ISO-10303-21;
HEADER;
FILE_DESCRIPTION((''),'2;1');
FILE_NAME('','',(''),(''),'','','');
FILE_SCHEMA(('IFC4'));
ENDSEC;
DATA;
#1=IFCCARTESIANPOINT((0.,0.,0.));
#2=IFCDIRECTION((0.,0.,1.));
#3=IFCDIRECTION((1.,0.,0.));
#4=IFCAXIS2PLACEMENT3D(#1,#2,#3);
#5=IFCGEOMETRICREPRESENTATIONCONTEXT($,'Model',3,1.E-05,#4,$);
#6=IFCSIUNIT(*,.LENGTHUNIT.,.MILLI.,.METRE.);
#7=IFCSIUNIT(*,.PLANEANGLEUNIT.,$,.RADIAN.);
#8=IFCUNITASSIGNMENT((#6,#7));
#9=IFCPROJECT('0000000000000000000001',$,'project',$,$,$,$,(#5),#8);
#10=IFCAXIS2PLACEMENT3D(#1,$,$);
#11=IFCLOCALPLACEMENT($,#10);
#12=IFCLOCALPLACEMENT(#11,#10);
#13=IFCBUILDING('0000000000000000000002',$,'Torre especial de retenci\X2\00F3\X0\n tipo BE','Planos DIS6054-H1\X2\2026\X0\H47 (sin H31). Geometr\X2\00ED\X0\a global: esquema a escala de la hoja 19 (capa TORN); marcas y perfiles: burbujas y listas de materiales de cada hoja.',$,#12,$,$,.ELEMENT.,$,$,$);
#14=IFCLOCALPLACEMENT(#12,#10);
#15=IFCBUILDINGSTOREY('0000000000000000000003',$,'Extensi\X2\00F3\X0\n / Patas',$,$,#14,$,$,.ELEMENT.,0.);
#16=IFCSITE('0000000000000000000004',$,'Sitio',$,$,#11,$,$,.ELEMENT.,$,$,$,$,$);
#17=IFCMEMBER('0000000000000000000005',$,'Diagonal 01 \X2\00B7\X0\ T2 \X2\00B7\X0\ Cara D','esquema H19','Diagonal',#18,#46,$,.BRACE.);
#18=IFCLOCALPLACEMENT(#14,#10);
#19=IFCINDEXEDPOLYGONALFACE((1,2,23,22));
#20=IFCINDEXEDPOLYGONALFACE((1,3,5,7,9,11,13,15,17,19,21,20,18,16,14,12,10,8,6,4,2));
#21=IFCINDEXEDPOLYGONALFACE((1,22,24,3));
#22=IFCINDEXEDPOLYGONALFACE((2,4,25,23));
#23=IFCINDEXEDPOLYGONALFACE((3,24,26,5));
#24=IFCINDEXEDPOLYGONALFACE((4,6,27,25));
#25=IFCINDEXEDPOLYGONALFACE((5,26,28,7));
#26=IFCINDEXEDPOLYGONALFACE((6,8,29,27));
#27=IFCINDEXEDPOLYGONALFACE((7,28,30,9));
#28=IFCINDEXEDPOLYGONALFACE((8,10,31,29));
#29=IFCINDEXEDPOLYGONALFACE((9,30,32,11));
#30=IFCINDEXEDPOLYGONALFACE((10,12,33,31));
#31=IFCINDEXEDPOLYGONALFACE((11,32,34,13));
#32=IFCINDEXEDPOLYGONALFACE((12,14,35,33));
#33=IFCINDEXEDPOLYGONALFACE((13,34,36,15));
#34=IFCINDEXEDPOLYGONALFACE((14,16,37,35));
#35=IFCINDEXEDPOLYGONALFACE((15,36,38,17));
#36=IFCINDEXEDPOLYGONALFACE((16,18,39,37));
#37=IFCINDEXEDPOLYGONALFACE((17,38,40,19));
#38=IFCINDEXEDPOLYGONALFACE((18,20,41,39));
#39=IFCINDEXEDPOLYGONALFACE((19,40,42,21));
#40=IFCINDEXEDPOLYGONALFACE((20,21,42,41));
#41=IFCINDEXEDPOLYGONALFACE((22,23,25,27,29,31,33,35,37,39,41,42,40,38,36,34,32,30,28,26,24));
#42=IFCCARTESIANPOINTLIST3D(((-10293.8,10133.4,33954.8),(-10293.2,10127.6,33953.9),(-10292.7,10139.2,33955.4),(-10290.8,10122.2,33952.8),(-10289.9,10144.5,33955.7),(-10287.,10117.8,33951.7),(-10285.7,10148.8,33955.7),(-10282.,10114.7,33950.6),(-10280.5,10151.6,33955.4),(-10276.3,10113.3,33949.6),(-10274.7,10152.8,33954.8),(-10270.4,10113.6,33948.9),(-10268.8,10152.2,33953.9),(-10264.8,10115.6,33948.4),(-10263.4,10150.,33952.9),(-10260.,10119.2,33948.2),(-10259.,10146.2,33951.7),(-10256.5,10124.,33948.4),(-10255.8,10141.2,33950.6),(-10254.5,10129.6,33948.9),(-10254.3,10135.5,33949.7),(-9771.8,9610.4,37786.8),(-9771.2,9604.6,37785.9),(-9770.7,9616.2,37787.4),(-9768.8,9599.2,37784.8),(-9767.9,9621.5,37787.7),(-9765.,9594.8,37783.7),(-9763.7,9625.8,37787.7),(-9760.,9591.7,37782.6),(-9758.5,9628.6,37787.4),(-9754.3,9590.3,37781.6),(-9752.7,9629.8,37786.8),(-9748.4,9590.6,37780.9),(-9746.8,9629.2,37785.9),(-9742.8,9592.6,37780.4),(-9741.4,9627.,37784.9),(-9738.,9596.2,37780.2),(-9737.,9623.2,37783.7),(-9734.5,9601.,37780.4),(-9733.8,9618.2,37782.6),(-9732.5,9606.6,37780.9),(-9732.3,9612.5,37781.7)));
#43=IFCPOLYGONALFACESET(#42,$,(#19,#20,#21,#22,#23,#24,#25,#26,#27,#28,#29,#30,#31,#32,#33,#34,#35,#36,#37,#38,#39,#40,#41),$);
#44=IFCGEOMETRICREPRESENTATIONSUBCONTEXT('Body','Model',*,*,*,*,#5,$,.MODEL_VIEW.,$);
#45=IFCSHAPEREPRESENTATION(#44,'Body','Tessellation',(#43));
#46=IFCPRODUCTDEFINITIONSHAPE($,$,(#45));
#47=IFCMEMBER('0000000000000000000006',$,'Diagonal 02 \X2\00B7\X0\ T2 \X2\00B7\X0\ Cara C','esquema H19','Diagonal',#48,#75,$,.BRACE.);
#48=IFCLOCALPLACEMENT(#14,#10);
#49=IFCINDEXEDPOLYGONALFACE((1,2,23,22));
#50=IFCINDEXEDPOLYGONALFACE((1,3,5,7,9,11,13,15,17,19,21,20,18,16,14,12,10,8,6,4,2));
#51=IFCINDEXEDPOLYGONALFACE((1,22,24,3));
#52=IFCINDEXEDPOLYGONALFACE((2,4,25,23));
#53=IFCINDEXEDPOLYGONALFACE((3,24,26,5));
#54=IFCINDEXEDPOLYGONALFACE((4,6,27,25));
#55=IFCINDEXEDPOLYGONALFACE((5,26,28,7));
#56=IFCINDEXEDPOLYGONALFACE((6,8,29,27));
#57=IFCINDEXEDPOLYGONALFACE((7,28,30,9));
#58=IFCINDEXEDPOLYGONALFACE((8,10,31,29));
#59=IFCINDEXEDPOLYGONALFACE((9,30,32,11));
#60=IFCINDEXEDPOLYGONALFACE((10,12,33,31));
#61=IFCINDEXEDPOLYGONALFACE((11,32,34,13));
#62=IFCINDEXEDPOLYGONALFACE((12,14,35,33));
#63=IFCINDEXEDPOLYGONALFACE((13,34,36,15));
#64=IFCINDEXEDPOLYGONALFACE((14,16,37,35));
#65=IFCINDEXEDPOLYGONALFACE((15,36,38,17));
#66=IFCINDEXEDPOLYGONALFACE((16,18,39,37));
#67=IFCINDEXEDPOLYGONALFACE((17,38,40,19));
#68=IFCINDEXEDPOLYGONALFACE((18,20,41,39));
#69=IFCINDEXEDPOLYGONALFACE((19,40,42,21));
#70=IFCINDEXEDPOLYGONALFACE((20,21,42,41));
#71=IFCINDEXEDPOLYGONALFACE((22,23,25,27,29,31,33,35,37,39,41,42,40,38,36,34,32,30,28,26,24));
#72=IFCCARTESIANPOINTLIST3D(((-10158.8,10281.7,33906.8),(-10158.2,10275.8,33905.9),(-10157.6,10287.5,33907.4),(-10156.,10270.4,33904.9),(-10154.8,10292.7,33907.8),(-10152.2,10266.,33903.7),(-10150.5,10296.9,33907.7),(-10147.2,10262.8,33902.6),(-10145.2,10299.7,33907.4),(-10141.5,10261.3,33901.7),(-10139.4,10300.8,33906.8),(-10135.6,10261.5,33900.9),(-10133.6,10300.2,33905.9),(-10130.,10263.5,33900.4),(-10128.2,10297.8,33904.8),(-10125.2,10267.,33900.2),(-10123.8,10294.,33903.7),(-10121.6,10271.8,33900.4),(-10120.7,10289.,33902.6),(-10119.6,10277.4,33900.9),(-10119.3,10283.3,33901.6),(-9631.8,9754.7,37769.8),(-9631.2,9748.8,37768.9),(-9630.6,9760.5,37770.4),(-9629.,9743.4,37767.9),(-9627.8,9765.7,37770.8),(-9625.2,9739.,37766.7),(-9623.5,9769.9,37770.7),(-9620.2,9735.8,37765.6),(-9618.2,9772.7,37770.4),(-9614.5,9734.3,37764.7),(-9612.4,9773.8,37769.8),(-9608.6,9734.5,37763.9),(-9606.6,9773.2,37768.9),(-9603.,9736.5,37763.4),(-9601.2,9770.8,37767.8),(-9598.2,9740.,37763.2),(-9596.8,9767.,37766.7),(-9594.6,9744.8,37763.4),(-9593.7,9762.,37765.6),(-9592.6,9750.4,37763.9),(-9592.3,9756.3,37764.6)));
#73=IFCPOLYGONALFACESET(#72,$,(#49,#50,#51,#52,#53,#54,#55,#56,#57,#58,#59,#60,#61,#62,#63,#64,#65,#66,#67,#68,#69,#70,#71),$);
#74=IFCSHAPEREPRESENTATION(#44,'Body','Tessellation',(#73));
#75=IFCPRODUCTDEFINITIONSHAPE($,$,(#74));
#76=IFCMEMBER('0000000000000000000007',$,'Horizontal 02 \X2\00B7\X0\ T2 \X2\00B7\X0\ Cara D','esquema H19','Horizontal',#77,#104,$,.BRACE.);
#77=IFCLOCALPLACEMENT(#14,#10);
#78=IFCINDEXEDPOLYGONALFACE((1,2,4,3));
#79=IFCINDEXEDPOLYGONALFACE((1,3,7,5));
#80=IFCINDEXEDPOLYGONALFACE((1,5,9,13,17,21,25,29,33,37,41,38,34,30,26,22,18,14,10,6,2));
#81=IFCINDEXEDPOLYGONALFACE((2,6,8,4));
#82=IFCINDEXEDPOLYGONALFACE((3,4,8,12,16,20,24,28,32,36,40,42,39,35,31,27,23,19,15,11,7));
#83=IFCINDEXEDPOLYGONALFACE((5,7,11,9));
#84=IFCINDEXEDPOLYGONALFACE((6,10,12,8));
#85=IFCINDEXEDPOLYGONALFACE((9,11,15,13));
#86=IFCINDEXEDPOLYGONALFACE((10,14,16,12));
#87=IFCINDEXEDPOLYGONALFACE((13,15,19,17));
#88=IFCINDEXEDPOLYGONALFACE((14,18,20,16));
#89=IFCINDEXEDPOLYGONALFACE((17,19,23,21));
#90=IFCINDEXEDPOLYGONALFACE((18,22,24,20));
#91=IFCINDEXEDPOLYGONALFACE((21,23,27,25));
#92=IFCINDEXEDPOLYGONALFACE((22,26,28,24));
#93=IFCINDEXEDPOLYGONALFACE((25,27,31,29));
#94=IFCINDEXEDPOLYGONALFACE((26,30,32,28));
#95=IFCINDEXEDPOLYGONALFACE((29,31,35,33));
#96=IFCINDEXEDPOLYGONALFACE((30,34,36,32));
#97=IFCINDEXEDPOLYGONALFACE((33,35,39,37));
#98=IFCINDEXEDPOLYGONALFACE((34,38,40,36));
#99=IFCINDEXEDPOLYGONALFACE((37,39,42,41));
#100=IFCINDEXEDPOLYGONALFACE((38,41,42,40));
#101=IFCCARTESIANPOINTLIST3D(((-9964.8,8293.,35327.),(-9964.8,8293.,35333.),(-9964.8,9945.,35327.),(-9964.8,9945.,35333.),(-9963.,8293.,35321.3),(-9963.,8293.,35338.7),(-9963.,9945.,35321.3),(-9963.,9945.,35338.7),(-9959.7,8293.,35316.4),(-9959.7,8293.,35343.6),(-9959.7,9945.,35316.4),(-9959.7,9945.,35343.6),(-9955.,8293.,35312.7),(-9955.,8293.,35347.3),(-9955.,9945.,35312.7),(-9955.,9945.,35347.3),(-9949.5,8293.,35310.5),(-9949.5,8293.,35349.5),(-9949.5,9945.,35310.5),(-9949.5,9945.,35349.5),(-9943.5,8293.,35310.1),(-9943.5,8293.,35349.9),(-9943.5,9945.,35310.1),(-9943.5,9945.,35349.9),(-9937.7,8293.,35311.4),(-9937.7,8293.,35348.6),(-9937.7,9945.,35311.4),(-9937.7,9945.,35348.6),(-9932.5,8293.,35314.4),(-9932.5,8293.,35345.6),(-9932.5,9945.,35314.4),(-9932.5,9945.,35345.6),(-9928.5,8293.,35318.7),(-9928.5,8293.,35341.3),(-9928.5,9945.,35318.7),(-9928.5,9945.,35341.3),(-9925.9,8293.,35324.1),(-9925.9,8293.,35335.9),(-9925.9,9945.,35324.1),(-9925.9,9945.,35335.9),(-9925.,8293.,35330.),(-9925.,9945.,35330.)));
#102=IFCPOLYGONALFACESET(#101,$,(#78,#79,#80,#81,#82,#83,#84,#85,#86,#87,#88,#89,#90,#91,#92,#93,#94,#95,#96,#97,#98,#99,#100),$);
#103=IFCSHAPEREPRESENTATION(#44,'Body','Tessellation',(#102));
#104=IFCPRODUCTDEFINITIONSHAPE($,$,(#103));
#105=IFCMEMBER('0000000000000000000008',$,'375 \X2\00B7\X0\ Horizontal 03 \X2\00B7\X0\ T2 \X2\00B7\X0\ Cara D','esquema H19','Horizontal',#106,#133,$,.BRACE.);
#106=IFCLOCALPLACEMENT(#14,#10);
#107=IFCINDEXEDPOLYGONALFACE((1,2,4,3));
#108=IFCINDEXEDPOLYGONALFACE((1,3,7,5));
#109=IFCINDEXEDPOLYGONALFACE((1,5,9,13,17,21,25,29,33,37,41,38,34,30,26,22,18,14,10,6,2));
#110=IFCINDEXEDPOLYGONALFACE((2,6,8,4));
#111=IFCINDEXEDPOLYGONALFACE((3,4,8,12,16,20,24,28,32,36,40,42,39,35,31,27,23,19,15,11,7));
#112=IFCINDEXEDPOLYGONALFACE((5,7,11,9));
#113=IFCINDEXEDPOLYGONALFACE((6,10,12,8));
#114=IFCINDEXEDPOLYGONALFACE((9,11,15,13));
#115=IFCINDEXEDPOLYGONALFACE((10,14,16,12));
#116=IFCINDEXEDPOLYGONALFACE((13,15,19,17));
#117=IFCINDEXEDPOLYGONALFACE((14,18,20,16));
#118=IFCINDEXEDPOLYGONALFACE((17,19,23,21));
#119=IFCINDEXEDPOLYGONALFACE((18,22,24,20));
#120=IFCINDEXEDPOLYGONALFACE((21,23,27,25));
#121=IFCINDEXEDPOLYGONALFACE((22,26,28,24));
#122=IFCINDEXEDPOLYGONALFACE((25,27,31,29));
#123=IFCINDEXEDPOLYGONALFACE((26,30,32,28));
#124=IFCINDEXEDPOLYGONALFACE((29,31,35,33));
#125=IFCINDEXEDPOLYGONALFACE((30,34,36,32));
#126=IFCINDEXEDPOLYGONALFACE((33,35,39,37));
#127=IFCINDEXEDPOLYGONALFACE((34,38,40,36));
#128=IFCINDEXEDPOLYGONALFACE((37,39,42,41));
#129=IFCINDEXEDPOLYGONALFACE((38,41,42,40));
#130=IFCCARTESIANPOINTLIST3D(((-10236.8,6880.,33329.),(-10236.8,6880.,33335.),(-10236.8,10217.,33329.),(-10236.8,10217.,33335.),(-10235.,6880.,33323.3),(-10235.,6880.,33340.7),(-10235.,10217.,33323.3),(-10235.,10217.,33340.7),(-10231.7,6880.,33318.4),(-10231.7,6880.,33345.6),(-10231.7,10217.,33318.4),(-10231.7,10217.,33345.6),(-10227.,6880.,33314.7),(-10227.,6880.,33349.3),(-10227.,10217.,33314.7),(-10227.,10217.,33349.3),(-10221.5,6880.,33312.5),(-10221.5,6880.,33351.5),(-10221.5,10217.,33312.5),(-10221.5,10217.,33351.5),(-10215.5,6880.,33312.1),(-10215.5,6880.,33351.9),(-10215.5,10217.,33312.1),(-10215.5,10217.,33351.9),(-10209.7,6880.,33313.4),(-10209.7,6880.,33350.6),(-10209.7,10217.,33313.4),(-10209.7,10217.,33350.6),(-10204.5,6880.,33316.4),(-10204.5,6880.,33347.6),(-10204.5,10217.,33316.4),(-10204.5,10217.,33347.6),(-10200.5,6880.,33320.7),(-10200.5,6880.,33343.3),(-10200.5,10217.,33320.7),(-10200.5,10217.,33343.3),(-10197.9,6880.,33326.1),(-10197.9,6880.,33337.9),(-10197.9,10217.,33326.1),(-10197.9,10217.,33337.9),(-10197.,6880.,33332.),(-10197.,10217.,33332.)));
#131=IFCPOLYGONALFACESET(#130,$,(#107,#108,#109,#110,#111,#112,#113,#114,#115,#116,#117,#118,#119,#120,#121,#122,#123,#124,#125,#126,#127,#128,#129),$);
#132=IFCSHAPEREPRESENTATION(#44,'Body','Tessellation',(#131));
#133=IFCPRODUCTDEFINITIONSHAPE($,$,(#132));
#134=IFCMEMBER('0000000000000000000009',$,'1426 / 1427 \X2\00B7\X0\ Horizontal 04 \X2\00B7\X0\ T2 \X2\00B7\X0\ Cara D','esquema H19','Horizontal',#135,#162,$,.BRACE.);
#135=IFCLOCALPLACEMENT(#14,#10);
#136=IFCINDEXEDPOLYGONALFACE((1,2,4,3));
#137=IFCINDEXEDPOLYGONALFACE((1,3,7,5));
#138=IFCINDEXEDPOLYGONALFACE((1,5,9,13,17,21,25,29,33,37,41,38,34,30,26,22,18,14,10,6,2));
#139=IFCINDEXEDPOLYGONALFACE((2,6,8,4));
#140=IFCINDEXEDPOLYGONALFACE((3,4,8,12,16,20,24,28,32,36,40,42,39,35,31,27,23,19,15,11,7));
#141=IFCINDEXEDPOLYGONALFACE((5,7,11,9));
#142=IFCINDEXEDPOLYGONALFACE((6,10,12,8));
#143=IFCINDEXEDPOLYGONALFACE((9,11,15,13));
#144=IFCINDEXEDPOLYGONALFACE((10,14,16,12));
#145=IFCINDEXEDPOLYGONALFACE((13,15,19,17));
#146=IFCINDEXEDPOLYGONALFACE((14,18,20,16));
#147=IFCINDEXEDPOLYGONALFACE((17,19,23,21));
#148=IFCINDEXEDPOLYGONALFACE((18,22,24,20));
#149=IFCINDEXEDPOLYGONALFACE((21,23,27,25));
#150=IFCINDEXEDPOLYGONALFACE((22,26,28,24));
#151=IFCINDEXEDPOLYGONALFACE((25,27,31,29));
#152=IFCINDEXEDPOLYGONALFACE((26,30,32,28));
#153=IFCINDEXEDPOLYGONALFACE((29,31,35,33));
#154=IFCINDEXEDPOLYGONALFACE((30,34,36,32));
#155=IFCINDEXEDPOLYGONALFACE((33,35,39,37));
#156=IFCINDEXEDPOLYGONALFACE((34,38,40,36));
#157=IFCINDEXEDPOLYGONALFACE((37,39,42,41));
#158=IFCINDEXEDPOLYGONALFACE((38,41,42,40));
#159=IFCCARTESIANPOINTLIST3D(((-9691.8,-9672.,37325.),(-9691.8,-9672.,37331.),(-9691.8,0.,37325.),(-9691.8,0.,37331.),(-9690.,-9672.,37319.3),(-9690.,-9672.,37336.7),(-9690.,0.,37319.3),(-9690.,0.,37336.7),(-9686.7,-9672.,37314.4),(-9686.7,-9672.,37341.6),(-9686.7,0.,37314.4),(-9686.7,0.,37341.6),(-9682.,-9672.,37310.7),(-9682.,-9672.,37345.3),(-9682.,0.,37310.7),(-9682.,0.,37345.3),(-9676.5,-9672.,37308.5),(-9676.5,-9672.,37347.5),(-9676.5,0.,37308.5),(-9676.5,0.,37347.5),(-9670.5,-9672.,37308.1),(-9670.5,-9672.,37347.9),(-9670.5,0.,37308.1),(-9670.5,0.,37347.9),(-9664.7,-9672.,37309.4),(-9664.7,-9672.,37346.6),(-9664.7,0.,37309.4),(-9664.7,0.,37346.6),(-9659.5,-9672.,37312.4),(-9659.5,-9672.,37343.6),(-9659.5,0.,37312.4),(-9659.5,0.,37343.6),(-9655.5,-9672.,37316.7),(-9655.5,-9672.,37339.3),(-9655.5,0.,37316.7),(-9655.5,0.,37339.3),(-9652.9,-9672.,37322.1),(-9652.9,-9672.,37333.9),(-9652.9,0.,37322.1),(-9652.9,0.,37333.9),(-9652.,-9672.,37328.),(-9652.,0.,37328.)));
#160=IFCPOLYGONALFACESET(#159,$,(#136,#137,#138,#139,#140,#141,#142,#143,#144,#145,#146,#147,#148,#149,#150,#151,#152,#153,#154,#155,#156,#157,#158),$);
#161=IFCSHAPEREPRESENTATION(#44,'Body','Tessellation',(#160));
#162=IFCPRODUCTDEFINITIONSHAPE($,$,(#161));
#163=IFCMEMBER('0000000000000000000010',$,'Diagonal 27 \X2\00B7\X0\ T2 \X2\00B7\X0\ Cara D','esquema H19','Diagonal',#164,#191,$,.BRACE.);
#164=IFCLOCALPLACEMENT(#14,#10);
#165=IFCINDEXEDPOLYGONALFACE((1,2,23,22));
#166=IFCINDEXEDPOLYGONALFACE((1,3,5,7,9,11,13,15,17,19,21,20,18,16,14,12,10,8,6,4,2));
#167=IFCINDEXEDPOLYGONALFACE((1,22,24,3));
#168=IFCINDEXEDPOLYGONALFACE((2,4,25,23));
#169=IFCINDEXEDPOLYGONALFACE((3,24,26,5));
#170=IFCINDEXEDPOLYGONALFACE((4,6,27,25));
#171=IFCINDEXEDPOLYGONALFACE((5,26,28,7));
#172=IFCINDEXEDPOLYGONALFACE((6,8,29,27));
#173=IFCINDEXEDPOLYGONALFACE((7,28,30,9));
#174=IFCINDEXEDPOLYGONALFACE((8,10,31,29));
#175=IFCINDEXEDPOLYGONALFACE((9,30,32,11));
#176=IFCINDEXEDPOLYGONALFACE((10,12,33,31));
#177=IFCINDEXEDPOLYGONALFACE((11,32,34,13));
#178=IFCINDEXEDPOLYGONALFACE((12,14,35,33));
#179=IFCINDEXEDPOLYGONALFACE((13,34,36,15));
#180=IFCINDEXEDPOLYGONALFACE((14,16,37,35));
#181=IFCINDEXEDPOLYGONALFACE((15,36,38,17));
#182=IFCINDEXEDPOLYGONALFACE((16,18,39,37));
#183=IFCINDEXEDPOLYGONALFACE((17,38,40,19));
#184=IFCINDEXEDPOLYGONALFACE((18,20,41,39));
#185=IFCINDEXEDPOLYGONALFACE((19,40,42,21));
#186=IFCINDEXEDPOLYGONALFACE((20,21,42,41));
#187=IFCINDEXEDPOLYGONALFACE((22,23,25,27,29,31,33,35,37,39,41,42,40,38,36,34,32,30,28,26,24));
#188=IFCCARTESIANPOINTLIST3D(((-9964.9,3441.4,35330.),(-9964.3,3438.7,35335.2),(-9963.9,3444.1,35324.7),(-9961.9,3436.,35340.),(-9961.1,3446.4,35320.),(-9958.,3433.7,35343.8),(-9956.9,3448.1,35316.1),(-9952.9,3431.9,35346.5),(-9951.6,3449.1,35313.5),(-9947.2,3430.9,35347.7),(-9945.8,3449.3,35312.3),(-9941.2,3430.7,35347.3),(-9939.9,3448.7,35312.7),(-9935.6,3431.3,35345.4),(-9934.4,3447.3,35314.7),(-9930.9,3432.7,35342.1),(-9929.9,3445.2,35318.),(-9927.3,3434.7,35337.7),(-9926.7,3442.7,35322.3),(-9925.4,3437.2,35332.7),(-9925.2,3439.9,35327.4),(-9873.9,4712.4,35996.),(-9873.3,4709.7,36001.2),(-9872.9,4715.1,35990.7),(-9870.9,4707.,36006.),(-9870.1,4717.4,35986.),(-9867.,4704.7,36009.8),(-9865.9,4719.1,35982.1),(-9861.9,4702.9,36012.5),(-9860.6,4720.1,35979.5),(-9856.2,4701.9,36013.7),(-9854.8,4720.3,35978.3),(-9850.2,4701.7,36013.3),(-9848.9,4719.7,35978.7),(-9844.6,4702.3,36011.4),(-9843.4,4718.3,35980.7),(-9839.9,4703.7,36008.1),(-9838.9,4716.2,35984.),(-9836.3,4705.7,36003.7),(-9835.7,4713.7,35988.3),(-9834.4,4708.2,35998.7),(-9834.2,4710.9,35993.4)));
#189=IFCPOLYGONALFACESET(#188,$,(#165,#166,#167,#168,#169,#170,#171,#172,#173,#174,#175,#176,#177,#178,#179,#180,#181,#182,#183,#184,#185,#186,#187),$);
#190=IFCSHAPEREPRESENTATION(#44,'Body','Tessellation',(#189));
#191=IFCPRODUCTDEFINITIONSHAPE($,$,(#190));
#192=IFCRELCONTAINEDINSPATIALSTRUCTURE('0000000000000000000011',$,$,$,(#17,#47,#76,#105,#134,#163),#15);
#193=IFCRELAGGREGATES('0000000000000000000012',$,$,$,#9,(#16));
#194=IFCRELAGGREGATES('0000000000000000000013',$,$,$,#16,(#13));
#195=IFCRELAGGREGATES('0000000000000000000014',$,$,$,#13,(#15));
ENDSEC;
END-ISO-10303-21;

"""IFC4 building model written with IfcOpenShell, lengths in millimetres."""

from ifc_helpers import new_model, si_unit, frame, origin, origin_with_axes, place, context, subcontext, project, spatial, circle, extrude, element, save


model = new_model("IFC4")

# Units and contexts
model_context = context("Model", 3, precision=1e-05, world=origin_with_axes())
body_context = subcontext(model_context, "Body", "Model", "MODEL_VIEW")
ifc_project = project(units=[si_unit("LENGTHUNIT", "METRE", prefix="MILLI"), si_unit("PLANEANGLEUNIT", "RADIAN")], contexts=[model_context])

# Site, building, storey
site_placement = place(None, origin())
site = spatial("IfcSite", under=ifc_project, at=site_placement, Name="Sitio", CompositionType="ELEMENT")
building_placement = place(site_placement, origin())
building = spatial("IfcBuilding", under=site, at=building_placement, Name="Torre especial de retención tipo BE", Description="Planos DIS6054-H1…H47 (sin H31). Geometría global: esquema a escala de la hoja 19 (capa TORN); marcas y perfiles: burbujas y listas de materiales de cada hoja.", CompositionType="ELEMENT")
storey_placement = place(building_placement, origin())
storey = spatial("IfcBuildingStorey", under=building, at=storey_placement, Name="Extensión / Patas", CompositionType="ELEMENT", Elevation=0.0)

# Members
member_1_placement = place(storey_placement, frame((-10274.0, 10133.0, 33952.0), z_axis=(0.133757, -0.134013, 0.981911), x_axis=(0.699447, -0.689149, -0.189336)))
element("IfcMember", 1, at=member_1_placement, inside=storey, Name="Diagonal 01 · T2 · Cara D", Description="esquema H19", ObjectType="Diagonal", PredefinedType="BRACE", context=body_context, shape_type="SweptSolid", body=[
    extrude(circle(Radius=20.0), None, (0.0, 0.0, 1.0), 3902.6),
])
member_2_placement = place(storey_placement, frame((-10139.0, 10281.0, 33904.0), z_axis=(0.133952, -0.133952, 0.981893), x_axis=(0.689144, -0.699425, -0.189432)))
element("IfcMember", 2, at=member_2_placement, inside=storey, Name="Diagonal 02 · T2 · Cara C", Description="esquema H19", ObjectType="Diagonal", PredefinedType="BRACE", context=body_context, shape_type="SweptSolid", body=[
    extrude(circle(Radius=20.0), None, (0.0, 0.0, 1.0), 3934.2),
])
member_3_placement = place(storey_placement, frame((-9945.0, 8293.0, 35330.0), z_axis=(0.0, 1.0, 0.0), x_axis=(1.0, 0.0, 0.0)))
element("IfcMember", 3, at=member_3_placement, inside=storey, Name="Horizontal 02 · T2 · Cara D", Description="esquema H19", ObjectType="Horizontal", PredefinedType="BRACE", context=body_context, shape_type="SweptSolid", body=[
    extrude(circle(Radius=20.0), None, (0.0, 0.0, 1.0), 1652.0),
])
member_4_placement = place(storey_placement, frame((-10217.0, 6880.0, 33332.0), z_axis=(0.0, 1.0, 0.0), x_axis=(1.0, 0.0, 0.0)))
element("IfcMember", 4, at=member_4_placement, inside=storey, Name="375 · Horizontal 03 · T2 · Cara D", Description="esquema H19", ObjectType="Horizontal", PredefinedType="BRACE", context=body_context, shape_type="SweptSolid", body=[
    extrude(circle(Radius=20.0), None, (0.0, 0.0, 1.0), 3337.0),
])
member_5_placement = place(storey_placement, frame((-9672.0, 0.0, 37328.0), z_axis=(0.0, -1.0, 0.0), x_axis=(1.0, 0.0, 0.0)))
element("IfcMember", 5, at=member_5_placement, inside=storey, Name="1426 / 1427 · Horizontal 04 · T2 · Cara D", Description="esquema H19", ObjectType="Horizontal", PredefinedType="BRACE", context=body_context, shape_type="SweptSolid", body=[
    extrude(circle(Radius=20.0), None, (0.0, 0.0, 1.0), 9672.0),
])
member_6_placement = place(storey_placement, frame((-9945.0, 3440.0, 35330.0), z_axis=(0.063291, 0.883987, 0.463207), x_axis=(0.980966, -0.140479, 0.134055)))
element("IfcMember", 6, at=member_6_placement, inside=storey, Name="Diagonal 27 · T2 · Cara D", Description="esquema H19", ObjectType="Diagonal", PredefinedType="BRACE", context=body_context, shape_type="SweptSolid", body=[
    extrude(circle(Radius=20.0), None, (0.0, 0.0, 1.0), 1437.8),
])

save(model, "model.ifc")
